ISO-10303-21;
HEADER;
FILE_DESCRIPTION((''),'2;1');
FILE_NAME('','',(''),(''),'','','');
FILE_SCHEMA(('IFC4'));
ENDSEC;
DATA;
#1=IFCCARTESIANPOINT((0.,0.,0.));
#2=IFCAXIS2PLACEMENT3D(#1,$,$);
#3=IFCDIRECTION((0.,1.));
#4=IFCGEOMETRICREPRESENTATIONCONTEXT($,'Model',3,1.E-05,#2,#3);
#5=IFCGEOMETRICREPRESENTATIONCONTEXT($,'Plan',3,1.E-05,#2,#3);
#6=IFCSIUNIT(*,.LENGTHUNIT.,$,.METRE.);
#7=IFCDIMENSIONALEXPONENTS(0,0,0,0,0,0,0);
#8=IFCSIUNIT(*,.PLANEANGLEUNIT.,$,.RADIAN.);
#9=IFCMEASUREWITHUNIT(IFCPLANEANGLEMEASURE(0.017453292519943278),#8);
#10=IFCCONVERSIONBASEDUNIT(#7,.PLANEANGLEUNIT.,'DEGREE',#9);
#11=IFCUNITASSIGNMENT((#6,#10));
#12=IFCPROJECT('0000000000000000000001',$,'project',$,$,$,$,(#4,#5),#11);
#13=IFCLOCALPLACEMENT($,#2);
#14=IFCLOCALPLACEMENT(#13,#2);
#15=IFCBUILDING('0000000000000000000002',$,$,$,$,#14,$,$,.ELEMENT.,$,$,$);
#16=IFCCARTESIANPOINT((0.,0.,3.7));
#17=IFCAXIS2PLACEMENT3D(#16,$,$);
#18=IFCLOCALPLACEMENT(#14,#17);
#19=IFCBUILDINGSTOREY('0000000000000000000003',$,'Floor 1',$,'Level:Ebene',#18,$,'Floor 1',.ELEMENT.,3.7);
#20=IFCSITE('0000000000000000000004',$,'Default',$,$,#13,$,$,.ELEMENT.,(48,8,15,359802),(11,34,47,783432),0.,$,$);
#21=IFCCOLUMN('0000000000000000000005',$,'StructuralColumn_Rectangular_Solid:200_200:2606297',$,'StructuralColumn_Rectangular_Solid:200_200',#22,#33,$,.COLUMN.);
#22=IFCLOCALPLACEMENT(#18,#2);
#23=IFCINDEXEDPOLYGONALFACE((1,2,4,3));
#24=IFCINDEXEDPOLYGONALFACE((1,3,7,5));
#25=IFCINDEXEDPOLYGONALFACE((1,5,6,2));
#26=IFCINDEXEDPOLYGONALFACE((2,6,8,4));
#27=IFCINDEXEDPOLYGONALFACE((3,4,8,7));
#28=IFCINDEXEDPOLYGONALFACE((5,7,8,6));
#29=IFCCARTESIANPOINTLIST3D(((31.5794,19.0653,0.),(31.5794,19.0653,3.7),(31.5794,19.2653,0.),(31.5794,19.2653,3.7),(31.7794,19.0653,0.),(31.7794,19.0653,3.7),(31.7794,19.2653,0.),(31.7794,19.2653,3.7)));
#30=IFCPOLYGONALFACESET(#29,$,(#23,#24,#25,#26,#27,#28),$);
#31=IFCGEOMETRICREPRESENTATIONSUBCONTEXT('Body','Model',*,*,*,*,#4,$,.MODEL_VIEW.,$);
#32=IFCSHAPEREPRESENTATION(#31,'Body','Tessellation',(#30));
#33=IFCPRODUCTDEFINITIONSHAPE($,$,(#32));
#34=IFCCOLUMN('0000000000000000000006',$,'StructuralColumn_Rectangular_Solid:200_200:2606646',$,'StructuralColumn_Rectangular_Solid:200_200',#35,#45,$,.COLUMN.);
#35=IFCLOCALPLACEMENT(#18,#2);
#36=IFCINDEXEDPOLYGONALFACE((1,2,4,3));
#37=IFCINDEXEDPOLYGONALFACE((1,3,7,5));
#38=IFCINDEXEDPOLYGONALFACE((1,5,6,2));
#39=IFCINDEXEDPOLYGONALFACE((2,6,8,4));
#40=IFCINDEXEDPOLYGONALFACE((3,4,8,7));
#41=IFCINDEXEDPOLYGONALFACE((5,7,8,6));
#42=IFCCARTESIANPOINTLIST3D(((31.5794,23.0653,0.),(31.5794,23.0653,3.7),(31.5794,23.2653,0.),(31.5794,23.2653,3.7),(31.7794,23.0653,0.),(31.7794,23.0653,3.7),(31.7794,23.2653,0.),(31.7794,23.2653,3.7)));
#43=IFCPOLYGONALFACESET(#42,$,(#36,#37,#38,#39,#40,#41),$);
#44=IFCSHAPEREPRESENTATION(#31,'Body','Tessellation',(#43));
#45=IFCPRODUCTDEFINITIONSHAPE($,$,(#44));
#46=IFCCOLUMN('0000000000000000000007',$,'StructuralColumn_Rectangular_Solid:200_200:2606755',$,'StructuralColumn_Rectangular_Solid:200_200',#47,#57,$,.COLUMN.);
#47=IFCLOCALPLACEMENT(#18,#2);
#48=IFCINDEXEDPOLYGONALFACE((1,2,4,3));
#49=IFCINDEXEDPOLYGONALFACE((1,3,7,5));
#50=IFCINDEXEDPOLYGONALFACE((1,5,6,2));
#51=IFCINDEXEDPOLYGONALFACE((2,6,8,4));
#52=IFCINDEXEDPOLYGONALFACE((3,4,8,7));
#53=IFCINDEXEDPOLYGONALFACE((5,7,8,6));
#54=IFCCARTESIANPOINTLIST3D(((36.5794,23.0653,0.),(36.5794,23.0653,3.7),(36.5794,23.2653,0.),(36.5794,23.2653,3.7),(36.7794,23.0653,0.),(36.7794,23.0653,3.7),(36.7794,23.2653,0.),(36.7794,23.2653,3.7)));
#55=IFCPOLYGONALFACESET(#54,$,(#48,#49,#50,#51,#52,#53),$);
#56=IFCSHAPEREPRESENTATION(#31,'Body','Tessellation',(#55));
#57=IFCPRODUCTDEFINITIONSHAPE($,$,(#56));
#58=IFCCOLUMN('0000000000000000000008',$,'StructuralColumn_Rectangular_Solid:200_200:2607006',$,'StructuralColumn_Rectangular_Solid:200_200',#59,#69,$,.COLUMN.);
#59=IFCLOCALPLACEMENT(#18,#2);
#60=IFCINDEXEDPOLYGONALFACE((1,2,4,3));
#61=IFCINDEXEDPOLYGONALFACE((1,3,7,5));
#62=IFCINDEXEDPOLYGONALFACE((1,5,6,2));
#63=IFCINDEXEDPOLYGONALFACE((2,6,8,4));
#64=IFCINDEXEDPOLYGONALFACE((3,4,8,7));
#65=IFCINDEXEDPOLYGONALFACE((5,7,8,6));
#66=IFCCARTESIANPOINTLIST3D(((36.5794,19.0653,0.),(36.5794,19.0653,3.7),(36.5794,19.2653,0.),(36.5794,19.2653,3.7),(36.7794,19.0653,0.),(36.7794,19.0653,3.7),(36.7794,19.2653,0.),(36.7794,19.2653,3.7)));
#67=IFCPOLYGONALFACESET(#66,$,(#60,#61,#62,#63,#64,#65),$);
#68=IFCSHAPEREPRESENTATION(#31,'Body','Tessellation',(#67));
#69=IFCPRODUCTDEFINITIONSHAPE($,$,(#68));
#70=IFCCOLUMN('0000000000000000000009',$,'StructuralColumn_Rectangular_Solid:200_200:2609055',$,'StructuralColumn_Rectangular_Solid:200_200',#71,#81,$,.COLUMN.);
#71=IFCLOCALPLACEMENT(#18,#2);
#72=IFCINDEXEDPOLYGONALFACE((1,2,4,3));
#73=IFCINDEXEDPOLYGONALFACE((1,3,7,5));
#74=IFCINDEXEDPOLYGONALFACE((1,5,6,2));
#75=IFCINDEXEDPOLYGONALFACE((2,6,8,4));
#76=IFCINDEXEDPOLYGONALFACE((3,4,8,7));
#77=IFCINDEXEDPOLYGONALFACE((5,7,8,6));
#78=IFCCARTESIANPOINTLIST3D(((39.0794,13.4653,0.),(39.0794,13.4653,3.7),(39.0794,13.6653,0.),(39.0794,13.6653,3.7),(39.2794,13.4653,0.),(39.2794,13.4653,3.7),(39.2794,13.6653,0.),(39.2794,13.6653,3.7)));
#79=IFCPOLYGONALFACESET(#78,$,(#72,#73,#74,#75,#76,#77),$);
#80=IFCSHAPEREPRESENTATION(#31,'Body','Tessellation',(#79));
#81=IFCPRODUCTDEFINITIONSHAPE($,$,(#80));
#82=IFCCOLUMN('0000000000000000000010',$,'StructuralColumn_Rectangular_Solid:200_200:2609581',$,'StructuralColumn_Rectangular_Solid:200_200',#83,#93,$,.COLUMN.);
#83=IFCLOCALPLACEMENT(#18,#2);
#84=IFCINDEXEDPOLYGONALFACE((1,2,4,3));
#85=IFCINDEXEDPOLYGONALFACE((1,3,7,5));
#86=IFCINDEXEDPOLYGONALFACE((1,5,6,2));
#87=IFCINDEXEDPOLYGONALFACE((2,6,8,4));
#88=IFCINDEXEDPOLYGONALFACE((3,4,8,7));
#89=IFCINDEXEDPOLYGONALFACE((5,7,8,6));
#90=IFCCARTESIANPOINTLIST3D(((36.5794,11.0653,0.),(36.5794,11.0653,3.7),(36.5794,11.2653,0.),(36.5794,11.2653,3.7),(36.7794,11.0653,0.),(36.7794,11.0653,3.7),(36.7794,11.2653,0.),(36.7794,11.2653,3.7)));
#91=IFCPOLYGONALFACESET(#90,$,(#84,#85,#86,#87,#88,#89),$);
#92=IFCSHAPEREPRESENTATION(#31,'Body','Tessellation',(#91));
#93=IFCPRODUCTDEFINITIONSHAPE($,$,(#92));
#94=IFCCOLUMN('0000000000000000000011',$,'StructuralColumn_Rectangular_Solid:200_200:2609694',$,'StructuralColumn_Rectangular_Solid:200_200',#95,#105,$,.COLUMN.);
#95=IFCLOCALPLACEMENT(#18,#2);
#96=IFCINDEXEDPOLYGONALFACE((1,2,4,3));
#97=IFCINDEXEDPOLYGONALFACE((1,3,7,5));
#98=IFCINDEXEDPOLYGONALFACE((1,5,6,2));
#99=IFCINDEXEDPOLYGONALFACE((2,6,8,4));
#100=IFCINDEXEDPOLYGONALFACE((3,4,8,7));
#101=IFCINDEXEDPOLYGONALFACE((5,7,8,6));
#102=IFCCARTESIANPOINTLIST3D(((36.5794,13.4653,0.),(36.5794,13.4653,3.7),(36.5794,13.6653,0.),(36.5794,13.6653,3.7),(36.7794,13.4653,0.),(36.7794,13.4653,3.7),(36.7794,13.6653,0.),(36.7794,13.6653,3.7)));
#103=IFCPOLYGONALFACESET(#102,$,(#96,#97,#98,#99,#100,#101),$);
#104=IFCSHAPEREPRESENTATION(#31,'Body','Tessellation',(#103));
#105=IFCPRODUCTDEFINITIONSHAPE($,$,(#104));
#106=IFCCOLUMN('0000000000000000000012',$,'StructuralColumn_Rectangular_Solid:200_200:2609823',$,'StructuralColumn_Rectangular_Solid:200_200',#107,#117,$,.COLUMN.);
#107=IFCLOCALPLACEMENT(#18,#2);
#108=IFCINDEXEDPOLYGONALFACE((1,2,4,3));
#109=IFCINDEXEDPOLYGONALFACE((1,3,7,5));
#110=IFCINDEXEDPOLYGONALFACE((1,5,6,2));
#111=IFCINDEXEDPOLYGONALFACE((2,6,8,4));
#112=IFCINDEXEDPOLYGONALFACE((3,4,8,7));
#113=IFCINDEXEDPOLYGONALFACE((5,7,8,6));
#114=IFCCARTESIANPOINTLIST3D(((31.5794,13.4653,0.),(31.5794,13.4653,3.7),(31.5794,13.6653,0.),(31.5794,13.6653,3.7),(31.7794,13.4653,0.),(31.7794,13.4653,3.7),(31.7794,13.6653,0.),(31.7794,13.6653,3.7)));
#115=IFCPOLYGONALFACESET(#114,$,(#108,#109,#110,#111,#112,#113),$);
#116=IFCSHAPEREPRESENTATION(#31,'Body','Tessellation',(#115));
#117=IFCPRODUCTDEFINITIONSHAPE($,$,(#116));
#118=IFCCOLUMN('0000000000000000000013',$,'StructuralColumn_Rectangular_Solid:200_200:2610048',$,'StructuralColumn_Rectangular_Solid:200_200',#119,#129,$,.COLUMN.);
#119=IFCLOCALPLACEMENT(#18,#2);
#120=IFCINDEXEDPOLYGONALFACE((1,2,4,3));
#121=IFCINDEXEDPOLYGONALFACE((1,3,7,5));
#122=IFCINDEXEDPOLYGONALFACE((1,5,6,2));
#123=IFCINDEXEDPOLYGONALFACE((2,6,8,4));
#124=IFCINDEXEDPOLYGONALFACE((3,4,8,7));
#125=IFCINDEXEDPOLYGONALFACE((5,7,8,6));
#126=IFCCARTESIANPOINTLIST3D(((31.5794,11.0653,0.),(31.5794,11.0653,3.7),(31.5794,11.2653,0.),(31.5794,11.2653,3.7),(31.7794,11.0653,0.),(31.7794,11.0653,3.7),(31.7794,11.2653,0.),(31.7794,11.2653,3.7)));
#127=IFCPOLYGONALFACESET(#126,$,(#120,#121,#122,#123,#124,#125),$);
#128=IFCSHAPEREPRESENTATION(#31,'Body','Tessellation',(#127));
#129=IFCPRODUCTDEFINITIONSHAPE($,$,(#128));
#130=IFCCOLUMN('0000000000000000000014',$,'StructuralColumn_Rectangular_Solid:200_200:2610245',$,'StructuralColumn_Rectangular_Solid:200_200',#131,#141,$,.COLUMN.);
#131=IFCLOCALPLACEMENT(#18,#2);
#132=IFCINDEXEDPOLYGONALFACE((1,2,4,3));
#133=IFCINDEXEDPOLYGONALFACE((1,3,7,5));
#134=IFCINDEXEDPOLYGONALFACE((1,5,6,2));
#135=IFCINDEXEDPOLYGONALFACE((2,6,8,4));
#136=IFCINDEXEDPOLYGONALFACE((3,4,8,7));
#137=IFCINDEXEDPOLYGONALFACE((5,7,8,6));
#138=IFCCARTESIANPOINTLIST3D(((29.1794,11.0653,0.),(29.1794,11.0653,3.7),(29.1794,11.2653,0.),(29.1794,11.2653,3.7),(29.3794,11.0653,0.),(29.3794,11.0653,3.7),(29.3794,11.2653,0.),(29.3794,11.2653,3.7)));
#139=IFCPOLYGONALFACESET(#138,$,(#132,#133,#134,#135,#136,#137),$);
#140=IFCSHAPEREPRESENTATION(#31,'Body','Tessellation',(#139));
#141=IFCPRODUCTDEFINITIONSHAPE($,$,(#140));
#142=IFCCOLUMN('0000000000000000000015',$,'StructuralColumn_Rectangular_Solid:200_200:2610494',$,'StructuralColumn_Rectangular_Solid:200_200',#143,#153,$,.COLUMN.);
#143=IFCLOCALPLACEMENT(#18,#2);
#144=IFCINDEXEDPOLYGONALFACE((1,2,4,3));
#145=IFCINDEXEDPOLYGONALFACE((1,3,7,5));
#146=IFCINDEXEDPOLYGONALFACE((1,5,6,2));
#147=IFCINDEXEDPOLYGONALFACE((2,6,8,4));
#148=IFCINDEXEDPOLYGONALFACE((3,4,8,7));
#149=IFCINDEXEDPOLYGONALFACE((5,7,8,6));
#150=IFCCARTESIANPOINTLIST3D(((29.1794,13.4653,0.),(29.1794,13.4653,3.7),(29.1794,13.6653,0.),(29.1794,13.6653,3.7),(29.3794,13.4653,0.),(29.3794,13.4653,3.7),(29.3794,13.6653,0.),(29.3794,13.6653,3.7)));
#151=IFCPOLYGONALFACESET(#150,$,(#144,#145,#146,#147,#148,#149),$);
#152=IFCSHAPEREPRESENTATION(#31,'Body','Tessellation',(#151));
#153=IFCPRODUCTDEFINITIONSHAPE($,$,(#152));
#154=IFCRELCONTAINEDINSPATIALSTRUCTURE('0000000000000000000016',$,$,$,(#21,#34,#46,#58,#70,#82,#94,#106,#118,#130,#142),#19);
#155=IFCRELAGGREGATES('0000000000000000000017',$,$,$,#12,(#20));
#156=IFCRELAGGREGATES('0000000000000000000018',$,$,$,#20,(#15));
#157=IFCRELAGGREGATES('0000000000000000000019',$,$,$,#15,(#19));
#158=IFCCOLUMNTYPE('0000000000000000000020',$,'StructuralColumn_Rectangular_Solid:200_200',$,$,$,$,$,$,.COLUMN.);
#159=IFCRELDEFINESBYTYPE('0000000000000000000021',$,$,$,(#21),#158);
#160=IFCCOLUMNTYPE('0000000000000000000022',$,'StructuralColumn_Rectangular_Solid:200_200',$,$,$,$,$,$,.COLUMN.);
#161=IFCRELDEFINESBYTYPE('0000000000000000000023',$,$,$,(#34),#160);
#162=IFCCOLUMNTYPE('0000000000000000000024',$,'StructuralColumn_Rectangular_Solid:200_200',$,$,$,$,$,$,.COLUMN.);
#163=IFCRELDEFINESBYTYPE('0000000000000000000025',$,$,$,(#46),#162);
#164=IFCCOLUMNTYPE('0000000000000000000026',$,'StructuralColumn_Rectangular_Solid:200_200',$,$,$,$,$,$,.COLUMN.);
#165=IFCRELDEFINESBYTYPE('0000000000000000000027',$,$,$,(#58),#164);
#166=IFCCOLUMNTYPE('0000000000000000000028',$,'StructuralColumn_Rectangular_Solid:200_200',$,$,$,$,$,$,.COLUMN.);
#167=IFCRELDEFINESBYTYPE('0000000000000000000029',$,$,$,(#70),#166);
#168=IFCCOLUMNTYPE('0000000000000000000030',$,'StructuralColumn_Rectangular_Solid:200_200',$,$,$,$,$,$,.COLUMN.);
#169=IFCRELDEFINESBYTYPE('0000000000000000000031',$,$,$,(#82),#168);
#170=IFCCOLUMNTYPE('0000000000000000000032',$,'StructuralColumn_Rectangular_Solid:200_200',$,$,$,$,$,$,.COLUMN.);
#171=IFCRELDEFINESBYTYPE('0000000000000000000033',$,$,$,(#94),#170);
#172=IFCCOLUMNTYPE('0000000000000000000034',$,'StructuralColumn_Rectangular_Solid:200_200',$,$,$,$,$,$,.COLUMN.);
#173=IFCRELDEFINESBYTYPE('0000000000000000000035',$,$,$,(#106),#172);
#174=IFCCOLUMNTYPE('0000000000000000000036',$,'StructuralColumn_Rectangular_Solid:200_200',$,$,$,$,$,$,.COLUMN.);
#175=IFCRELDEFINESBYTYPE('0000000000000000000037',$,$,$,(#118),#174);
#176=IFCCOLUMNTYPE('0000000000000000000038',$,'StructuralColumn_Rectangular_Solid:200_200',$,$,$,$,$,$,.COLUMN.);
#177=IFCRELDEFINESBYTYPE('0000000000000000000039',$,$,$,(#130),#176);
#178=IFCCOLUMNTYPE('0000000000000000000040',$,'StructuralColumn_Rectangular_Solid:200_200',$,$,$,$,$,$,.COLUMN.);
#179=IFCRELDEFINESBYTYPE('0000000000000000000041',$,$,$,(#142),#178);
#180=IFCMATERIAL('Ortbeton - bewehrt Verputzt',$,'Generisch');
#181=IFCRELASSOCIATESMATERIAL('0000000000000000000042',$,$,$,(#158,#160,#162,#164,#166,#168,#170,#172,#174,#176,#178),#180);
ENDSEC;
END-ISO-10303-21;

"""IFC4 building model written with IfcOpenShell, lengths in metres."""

from ifc_helpers import new_model, entity, si_unit, converted_unit, direction, frame, frame_2d, origin, origin_2d_with_axis, place, context, subcontext, project, spatial, rectangle, extrude, source, transform, mapped, material, material_profile, profile_set, type_object, type_shapes, element, save


model = new_model("IFC4")

# Units and contexts
model_context = context("Model", 3, precision=1e-05, world=origin(), true_north=direction((0.0, 1.0)))
plan_context = context("Plan", 3, precision=1e-05, world=origin(), true_north=direction((0.0, 1.0)))
body_context = subcontext(model_context, "Body", "Model", "MODEL_VIEW")
ifc_project = project(units=[si_unit("LENGTHUNIT", "METRE"), converted_unit("PLANEANGLEUNIT", "DEGREE", entity("IfcPlaneAngleMeasure", 0.017453292519943278), si_unit("PLANEANGLEUNIT", "RADIAN"), dimensions=[0, 0, 0, 0, 0, 0, 0])], contexts=[model_context, plan_context])

# Site, building, storey
site_placement = place(None, origin())
site = spatial("IfcSite", under=ifc_project, at=site_placement, Name="Default", CompositionType="ELEMENT", RefLatitude=(48, 8, 15, 359802), RefLongitude=(11, 34, 47, 783432), RefElevation=0.0)
building_placement = place(site_placement, origin())
building = spatial("IfcBuilding", under=site, at=building_placement, CompositionType="ELEMENT")
storey_placement = place(building_placement, frame((0.0, 0.0, 3.7)))
storey = spatial("IfcBuildingStorey", under=building, at=storey_placement, Name="Floor 1", ObjectType="Level:Ebene", LongName="Floor 1", CompositionType="ELEMENT", Elevation=3.7)

# Columns
ifc_material_1 = material(Name="Ortbeton - bewehrt Verputzt", Category="Generisch")
ifc_material_profile = material_profile(ifc_material_1, rectangle(XDim=0.2, YDim=0.2, at=frame_2d((0.0, 0.0), x_axis=(1.0, 0.0))), Name="200_200")
ifc_profile_set = profile_set([ifc_material_profile], Name="200_200")
column_type_1 = type_object("IfcColumnType", Name="StructuralColumn_Rectangular_Solid:200_200", PredefinedType="COLUMN", material=ifc_profile_set)
shared_shape_1 = source(origin(), body_context, "Body", "SweptSolid", [
    extrude(rectangle(XDim=0.2, YDim=0.2, at=frame_2d((0.0, 0.0), x_axis=(1.0, 0.0))), frame((31.6794, 19.1653, 3.7), z_axis=(0.0, 0.0, 1.0), x_axis=(-1.0, 0.0, 0.0)), (0.0, 0.0, 1.0), 3.7),
])
type_shapes(column_type_1, [shared_shape_1])
column_1_placement = place(storey_placement, frame((0.0, 0.0, -3.7)))
element("IfcColumn", 1, at=column_1_placement, inside=storey, type_object=column_type_1, Name="StructuralColumn_Rectangular_Solid:200_200:2606297", ObjectType="StructuralColumn_Rectangular_Solid:200_200", PredefinedType="COLUMN", context=body_context, shape_type="MappedRepresentation", body=[
    mapped(shared_shape_1, transform((0.0, 0.0, 0.0), scale=1.0)),
])
column_type_2 = type_object("IfcColumnType", Name="StructuralColumn_Rectangular_Solid:200_200", PredefinedType="COLUMN", material=ifc_profile_set)
shared_shape_2 = source(origin(), body_context, "Body", "SweptSolid", [
    extrude(rectangle(XDim=0.2, YDim=0.2, at=origin_2d_with_axis()), frame((31.6794, 23.1653, 3.7), z_axis=(0.0, 0.0, 1.0), x_axis=(-1.0, 0.0, 0.0)), (0.0, 0.0, 1.0), 3.7),
])
type_shapes(column_type_2, [shared_shape_2])
column_2_placement = place(storey_placement, frame((0.0, 0.0, -3.7)))
element("IfcColumn", 2, at=column_2_placement, inside=storey, type_object=column_type_2, Name="StructuralColumn_Rectangular_Solid:200_200:2606646", ObjectType="StructuralColumn_Rectangular_Solid:200_200", PredefinedType="COLUMN", context=body_context, shape_type="MappedRepresentation", body=[
    mapped(shared_shape_2, transform((0.0, 0.0, 0.0), scale=1.0)),
])
column_type_3 = type_object("IfcColumnType", Name="StructuralColumn_Rectangular_Solid:200_200", PredefinedType="COLUMN", material=ifc_profile_set)
shared_shape_3 = source(origin(), body_context, "Body", "SweptSolid", [
    extrude(rectangle(XDim=0.2, YDim=0.2, at=origin_2d_with_axis()), frame((36.6794, 23.1653, 3.7), z_axis=(0.0, 0.0, 1.0), x_axis=(-1.0, 0.0, 0.0)), (0.0, 0.0, 1.0), 3.7),
])
type_shapes(column_type_3, [shared_shape_3])
column_3_placement = place(storey_placement, frame((0.0, 0.0, -3.7)))
element("IfcColumn", 3, at=column_3_placement, inside=storey, type_object=column_type_3, Name="StructuralColumn_Rectangular_Solid:200_200:2606755", ObjectType="StructuralColumn_Rectangular_Solid:200_200", PredefinedType="COLUMN", context=body_context, shape_type="MappedRepresentation", body=[
    mapped(shared_shape_3, transform((0.0, 0.0, 0.0), scale=1.0)),
])
column_type_4 = type_object("IfcColumnType", Name="StructuralColumn_Rectangular_Solid:200_200", PredefinedType="COLUMN", material=ifc_profile_set)
shared_shape_4 = source(origin(), body_context, "Body", "SweptSolid", [
    extrude(rectangle(XDim=0.2, YDim=0.2, at=frame_2d((0.0, 0.0), x_axis=(1.0, 0.0))), frame((36.6794, 19.1653, 3.7), z_axis=(0.0, 0.0, 1.0), x_axis=(-1.0, 0.0, 0.0)), (0.0, 0.0, 1.0), 3.7),
])
type_shapes(column_type_4, [shared_shape_4])
column_4_placement = place(storey_placement, frame((0.0, 0.0, -3.7)))
element("IfcColumn", 4, at=column_4_placement, inside=storey, type_object=column_type_4, Name="StructuralColumn_Rectangular_Solid:200_200:2607006", ObjectType="StructuralColumn_Rectangular_Solid:200_200", PredefinedType="COLUMN", context=body_context, shape_type="MappedRepresentation", body=[
    mapped(shared_shape_4, transform((0.0, 0.0, 0.0), scale=1.0)),
])
column_type_5 = type_object("IfcColumnType", Name="StructuralColumn_Rectangular_Solid:200_200", PredefinedType="COLUMN", material=ifc_profile_set)
shared_shape_5 = source(origin(), body_context, "Body", "SweptSolid", [
    extrude(rectangle(XDim=0.2, YDim=0.2, at=frame_2d((0.0, 0.0), x_axis=(1.0, 0.0))), frame((39.1794, 13.5653, 3.7), z_axis=(0.0, 0.0, 1.0), x_axis=(-1.0, 0.0, 0.0)), (0.0, 0.0, 1.0), 3.7),
])
type_shapes(column_type_5, [shared_shape_5])
column_5_placement = place(storey_placement, frame((0.0, 0.0, -3.7)))
element("IfcColumn", 5, at=column_5_placement, inside=storey, type_object=column_type_5, Name="StructuralColumn_Rectangular_Solid:200_200:2609055", ObjectType="StructuralColumn_Rectangular_Solid:200_200", PredefinedType="COLUMN", context=body_context, shape_type="MappedRepresentation", body=[
    mapped(shared_shape_5, transform((0.0, 0.0, 0.0), scale=1.0)),
])
column_type_6 = type_object("IfcColumnType", Name="StructuralColumn_Rectangular_Solid:200_200", PredefinedType="COLUMN", material=ifc_profile_set)
shared_shape_6 = source(origin(), body_context, "Body", "SweptSolid", [
    extrude(rectangle(XDim=0.2, YDim=0.2, at=frame_2d((0.0, 0.0), x_axis=(1.0, 0.0))), frame((36.6794, 11.1653, 3.7), z_axis=(0.0, 0.0, 1.0), x_axis=(-1.0, 0.0, 0.0)), (0.0, 0.0, 1.0), 3.7),
])
type_shapes(column_type_6, [shared_shape_6])
column_6_placement = place(storey_placement, frame((0.0, 0.0, -3.7)))
element("IfcColumn", 6, at=column_6_placement, inside=storey, type_object=column_type_6, Name="StructuralColumn_Rectangular_Solid:200_200:2609581", ObjectType="StructuralColumn_Rectangular_Solid:200_200", PredefinedType="COLUMN", context=body_context, shape_type="MappedRepresentation", body=[
    mapped(shared_shape_6, transform((0.0, 0.0, 0.0), scale=1.0)),
])
column_type_7 = type_object("IfcColumnType", Name="StructuralColumn_Rectangular_Solid:200_200", PredefinedType="COLUMN", material=ifc_profile_set)
shared_shape_7 = source(origin(), body_context, "Body", "SweptSolid", [
    extrude(rectangle(XDim=0.2, YDim=0.2, at=frame_2d((0.0, 0.0), x_axis=(1.0, 0.0))), frame((36.6794, 13.5653, 3.7), z_axis=(0.0, 0.0, 1.0), x_axis=(-1.0, 0.0, 0.0)), (0.0, 0.0, 1.0), 3.7),
])
type_shapes(column_type_7, [shared_shape_7])
column_7_placement = place(storey_placement, frame((0.0, 0.0, -3.7)))
element("IfcColumn", 7, at=column_7_placement, inside=storey, type_object=column_type_7, Name="StructuralColumn_Rectangular_Solid:200_200:2609694", ObjectType="StructuralColumn_Rectangular_Solid:200_200", PredefinedType="COLUMN", context=body_context, shape_type="MappedRepresentation", body=[
    mapped(shared_shape_7, transform((0.0, 0.0, 0.0), scale=1.0)),
])
column_type_8 = type_object("IfcColumnType", Name="StructuralColumn_Rectangular_Solid:200_200", PredefinedType="COLUMN", material=ifc_profile_set)
shared_shape_8 = source(origin(), body_context, "Body", "SweptSolid", [
    extrude(rectangle(XDim=0.2, YDim=0.2, at=frame_2d((0.0, 0.0), x_axis=(1.0, 0.0))), frame((31.6794, 13.5653, 3.7), z_axis=(0.0, 0.0, 1.0), x_axis=(-1.0, 0.0, 0.0)), (0.0, 0.0, 1.0), 3.7),
])
type_shapes(column_type_8, [shared_shape_8])
column_8_placement = place(storey_placement, frame((0.0, 0.0, -3.7)))
element("IfcColumn", 8, at=column_8_placement, inside=storey, type_object=column_type_8, Name="StructuralColumn_Rectangular_Solid:200_200:2609823", ObjectType="StructuralColumn_Rectangular_Solid:200_200", PredefinedType="COLUMN", context=body_context, shape_type="MappedRepresentation", body=[
    mapped(shared_shape_8, transform((0.0, 0.0, 0.0), scale=1.0)),
])
column_type_9 = type_object("IfcColumnType", Name="StructuralColumn_Rectangular_Solid:200_200", PredefinedType="COLUMN", material=ifc_profile_set)
shared_shape_9 = source(origin(), body_context, "Body", "SweptSolid", [
    extrude(rectangle(XDim=0.2, YDim=0.2, at=frame_2d((0.0, 0.0), x_axis=(1.0, 0.0))), frame((31.6794, 11.1653, 3.7), z_axis=(0.0, 0.0, 1.0), x_axis=(-1.0, 0.0, 0.0)), (0.0, 0.0, 1.0), 3.7),
])
type_shapes(column_type_9, [shared_shape_9])
column_9_placement = place(storey_placement, frame((0.0, 0.0, -3.7)))
element("IfcColumn", 9, at=column_9_placement, inside=storey, type_object=column_type_9, Name="StructuralColumn_Rectangular_Solid:200_200:2610048", ObjectType="StructuralColumn_Rectangular_Solid:200_200", PredefinedType="COLUMN", context=body_context, shape_type="MappedRepresentation", body=[
    mapped(shared_shape_9, transform((0.0, 0.0, 0.0), scale=1.0)),
])
column_type_10 = type_object("IfcColumnType", Name="StructuralColumn_Rectangular_Solid:200_200", PredefinedType="COLUMN", material=ifc_profile_set)
shared_shape_10 = source(origin(), body_context, "Body", "SweptSolid", [
    extrude(rectangle(XDim=0.2, YDim=0.2, at=frame_2d((0.0, 0.0), x_axis=(1.0, 0.0))), frame((29.2794, 11.1653, 3.7), z_axis=(0.0, 0.0, 1.0), x_axis=(-1.0, 0.0, 0.0)), (0.0, 0.0, 1.0), 3.7),
])
type_shapes(column_type_10, [shared_shape_10])
column_10_placement = place(storey_placement, frame((0.0, 0.0, -3.7)))
element("IfcColumn", 10, at=column_10_placement, inside=storey, type_object=column_type_10, Name="StructuralColumn_Rectangular_Solid:200_200:2610245", ObjectType="StructuralColumn_Rectangular_Solid:200_200", PredefinedType="COLUMN", context=body_context, shape_type="MappedRepresentation", body=[
    mapped(shared_shape_10, transform((0.0, 0.0, 0.0), scale=1.0)),
])
column_type_11 = type_object("IfcColumnType", Name="StructuralColumn_Rectangular_Solid:200_200", PredefinedType="COLUMN", material=ifc_profile_set)
shared_shape_11 = source(origin(), body_context, "Body", "SweptSolid", [
    extrude(rectangle(XDim=0.2, YDim=0.2, at=frame_2d((0.0, 0.0), x_axis=(1.0, 0.0))), frame((29.2794, 13.5653, 3.7), z_axis=(0.0, 0.0, 1.0), x_axis=(-1.0, 0.0, 0.0)), (0.0, 0.0, 1.0), 3.7),
])
type_shapes(column_type_11, [shared_shape_11])
column_11_placement = place(storey_placement, frame((0.0, 0.0, -3.7)))
element("IfcColumn", 11, at=column_11_placement, inside=storey, type_object=column_type_11, Name="StructuralColumn_Rectangular_Solid:200_200:2610494", ObjectType="StructuralColumn_Rectangular_Solid:200_200", PredefinedType="COLUMN", context=body_context, shape_type="MappedRepresentation", body=[
    mapped(shared_shape_11, transform((0.0, 0.0, 0.0), scale=1.0)),
])

save(model, "model.ifc")
